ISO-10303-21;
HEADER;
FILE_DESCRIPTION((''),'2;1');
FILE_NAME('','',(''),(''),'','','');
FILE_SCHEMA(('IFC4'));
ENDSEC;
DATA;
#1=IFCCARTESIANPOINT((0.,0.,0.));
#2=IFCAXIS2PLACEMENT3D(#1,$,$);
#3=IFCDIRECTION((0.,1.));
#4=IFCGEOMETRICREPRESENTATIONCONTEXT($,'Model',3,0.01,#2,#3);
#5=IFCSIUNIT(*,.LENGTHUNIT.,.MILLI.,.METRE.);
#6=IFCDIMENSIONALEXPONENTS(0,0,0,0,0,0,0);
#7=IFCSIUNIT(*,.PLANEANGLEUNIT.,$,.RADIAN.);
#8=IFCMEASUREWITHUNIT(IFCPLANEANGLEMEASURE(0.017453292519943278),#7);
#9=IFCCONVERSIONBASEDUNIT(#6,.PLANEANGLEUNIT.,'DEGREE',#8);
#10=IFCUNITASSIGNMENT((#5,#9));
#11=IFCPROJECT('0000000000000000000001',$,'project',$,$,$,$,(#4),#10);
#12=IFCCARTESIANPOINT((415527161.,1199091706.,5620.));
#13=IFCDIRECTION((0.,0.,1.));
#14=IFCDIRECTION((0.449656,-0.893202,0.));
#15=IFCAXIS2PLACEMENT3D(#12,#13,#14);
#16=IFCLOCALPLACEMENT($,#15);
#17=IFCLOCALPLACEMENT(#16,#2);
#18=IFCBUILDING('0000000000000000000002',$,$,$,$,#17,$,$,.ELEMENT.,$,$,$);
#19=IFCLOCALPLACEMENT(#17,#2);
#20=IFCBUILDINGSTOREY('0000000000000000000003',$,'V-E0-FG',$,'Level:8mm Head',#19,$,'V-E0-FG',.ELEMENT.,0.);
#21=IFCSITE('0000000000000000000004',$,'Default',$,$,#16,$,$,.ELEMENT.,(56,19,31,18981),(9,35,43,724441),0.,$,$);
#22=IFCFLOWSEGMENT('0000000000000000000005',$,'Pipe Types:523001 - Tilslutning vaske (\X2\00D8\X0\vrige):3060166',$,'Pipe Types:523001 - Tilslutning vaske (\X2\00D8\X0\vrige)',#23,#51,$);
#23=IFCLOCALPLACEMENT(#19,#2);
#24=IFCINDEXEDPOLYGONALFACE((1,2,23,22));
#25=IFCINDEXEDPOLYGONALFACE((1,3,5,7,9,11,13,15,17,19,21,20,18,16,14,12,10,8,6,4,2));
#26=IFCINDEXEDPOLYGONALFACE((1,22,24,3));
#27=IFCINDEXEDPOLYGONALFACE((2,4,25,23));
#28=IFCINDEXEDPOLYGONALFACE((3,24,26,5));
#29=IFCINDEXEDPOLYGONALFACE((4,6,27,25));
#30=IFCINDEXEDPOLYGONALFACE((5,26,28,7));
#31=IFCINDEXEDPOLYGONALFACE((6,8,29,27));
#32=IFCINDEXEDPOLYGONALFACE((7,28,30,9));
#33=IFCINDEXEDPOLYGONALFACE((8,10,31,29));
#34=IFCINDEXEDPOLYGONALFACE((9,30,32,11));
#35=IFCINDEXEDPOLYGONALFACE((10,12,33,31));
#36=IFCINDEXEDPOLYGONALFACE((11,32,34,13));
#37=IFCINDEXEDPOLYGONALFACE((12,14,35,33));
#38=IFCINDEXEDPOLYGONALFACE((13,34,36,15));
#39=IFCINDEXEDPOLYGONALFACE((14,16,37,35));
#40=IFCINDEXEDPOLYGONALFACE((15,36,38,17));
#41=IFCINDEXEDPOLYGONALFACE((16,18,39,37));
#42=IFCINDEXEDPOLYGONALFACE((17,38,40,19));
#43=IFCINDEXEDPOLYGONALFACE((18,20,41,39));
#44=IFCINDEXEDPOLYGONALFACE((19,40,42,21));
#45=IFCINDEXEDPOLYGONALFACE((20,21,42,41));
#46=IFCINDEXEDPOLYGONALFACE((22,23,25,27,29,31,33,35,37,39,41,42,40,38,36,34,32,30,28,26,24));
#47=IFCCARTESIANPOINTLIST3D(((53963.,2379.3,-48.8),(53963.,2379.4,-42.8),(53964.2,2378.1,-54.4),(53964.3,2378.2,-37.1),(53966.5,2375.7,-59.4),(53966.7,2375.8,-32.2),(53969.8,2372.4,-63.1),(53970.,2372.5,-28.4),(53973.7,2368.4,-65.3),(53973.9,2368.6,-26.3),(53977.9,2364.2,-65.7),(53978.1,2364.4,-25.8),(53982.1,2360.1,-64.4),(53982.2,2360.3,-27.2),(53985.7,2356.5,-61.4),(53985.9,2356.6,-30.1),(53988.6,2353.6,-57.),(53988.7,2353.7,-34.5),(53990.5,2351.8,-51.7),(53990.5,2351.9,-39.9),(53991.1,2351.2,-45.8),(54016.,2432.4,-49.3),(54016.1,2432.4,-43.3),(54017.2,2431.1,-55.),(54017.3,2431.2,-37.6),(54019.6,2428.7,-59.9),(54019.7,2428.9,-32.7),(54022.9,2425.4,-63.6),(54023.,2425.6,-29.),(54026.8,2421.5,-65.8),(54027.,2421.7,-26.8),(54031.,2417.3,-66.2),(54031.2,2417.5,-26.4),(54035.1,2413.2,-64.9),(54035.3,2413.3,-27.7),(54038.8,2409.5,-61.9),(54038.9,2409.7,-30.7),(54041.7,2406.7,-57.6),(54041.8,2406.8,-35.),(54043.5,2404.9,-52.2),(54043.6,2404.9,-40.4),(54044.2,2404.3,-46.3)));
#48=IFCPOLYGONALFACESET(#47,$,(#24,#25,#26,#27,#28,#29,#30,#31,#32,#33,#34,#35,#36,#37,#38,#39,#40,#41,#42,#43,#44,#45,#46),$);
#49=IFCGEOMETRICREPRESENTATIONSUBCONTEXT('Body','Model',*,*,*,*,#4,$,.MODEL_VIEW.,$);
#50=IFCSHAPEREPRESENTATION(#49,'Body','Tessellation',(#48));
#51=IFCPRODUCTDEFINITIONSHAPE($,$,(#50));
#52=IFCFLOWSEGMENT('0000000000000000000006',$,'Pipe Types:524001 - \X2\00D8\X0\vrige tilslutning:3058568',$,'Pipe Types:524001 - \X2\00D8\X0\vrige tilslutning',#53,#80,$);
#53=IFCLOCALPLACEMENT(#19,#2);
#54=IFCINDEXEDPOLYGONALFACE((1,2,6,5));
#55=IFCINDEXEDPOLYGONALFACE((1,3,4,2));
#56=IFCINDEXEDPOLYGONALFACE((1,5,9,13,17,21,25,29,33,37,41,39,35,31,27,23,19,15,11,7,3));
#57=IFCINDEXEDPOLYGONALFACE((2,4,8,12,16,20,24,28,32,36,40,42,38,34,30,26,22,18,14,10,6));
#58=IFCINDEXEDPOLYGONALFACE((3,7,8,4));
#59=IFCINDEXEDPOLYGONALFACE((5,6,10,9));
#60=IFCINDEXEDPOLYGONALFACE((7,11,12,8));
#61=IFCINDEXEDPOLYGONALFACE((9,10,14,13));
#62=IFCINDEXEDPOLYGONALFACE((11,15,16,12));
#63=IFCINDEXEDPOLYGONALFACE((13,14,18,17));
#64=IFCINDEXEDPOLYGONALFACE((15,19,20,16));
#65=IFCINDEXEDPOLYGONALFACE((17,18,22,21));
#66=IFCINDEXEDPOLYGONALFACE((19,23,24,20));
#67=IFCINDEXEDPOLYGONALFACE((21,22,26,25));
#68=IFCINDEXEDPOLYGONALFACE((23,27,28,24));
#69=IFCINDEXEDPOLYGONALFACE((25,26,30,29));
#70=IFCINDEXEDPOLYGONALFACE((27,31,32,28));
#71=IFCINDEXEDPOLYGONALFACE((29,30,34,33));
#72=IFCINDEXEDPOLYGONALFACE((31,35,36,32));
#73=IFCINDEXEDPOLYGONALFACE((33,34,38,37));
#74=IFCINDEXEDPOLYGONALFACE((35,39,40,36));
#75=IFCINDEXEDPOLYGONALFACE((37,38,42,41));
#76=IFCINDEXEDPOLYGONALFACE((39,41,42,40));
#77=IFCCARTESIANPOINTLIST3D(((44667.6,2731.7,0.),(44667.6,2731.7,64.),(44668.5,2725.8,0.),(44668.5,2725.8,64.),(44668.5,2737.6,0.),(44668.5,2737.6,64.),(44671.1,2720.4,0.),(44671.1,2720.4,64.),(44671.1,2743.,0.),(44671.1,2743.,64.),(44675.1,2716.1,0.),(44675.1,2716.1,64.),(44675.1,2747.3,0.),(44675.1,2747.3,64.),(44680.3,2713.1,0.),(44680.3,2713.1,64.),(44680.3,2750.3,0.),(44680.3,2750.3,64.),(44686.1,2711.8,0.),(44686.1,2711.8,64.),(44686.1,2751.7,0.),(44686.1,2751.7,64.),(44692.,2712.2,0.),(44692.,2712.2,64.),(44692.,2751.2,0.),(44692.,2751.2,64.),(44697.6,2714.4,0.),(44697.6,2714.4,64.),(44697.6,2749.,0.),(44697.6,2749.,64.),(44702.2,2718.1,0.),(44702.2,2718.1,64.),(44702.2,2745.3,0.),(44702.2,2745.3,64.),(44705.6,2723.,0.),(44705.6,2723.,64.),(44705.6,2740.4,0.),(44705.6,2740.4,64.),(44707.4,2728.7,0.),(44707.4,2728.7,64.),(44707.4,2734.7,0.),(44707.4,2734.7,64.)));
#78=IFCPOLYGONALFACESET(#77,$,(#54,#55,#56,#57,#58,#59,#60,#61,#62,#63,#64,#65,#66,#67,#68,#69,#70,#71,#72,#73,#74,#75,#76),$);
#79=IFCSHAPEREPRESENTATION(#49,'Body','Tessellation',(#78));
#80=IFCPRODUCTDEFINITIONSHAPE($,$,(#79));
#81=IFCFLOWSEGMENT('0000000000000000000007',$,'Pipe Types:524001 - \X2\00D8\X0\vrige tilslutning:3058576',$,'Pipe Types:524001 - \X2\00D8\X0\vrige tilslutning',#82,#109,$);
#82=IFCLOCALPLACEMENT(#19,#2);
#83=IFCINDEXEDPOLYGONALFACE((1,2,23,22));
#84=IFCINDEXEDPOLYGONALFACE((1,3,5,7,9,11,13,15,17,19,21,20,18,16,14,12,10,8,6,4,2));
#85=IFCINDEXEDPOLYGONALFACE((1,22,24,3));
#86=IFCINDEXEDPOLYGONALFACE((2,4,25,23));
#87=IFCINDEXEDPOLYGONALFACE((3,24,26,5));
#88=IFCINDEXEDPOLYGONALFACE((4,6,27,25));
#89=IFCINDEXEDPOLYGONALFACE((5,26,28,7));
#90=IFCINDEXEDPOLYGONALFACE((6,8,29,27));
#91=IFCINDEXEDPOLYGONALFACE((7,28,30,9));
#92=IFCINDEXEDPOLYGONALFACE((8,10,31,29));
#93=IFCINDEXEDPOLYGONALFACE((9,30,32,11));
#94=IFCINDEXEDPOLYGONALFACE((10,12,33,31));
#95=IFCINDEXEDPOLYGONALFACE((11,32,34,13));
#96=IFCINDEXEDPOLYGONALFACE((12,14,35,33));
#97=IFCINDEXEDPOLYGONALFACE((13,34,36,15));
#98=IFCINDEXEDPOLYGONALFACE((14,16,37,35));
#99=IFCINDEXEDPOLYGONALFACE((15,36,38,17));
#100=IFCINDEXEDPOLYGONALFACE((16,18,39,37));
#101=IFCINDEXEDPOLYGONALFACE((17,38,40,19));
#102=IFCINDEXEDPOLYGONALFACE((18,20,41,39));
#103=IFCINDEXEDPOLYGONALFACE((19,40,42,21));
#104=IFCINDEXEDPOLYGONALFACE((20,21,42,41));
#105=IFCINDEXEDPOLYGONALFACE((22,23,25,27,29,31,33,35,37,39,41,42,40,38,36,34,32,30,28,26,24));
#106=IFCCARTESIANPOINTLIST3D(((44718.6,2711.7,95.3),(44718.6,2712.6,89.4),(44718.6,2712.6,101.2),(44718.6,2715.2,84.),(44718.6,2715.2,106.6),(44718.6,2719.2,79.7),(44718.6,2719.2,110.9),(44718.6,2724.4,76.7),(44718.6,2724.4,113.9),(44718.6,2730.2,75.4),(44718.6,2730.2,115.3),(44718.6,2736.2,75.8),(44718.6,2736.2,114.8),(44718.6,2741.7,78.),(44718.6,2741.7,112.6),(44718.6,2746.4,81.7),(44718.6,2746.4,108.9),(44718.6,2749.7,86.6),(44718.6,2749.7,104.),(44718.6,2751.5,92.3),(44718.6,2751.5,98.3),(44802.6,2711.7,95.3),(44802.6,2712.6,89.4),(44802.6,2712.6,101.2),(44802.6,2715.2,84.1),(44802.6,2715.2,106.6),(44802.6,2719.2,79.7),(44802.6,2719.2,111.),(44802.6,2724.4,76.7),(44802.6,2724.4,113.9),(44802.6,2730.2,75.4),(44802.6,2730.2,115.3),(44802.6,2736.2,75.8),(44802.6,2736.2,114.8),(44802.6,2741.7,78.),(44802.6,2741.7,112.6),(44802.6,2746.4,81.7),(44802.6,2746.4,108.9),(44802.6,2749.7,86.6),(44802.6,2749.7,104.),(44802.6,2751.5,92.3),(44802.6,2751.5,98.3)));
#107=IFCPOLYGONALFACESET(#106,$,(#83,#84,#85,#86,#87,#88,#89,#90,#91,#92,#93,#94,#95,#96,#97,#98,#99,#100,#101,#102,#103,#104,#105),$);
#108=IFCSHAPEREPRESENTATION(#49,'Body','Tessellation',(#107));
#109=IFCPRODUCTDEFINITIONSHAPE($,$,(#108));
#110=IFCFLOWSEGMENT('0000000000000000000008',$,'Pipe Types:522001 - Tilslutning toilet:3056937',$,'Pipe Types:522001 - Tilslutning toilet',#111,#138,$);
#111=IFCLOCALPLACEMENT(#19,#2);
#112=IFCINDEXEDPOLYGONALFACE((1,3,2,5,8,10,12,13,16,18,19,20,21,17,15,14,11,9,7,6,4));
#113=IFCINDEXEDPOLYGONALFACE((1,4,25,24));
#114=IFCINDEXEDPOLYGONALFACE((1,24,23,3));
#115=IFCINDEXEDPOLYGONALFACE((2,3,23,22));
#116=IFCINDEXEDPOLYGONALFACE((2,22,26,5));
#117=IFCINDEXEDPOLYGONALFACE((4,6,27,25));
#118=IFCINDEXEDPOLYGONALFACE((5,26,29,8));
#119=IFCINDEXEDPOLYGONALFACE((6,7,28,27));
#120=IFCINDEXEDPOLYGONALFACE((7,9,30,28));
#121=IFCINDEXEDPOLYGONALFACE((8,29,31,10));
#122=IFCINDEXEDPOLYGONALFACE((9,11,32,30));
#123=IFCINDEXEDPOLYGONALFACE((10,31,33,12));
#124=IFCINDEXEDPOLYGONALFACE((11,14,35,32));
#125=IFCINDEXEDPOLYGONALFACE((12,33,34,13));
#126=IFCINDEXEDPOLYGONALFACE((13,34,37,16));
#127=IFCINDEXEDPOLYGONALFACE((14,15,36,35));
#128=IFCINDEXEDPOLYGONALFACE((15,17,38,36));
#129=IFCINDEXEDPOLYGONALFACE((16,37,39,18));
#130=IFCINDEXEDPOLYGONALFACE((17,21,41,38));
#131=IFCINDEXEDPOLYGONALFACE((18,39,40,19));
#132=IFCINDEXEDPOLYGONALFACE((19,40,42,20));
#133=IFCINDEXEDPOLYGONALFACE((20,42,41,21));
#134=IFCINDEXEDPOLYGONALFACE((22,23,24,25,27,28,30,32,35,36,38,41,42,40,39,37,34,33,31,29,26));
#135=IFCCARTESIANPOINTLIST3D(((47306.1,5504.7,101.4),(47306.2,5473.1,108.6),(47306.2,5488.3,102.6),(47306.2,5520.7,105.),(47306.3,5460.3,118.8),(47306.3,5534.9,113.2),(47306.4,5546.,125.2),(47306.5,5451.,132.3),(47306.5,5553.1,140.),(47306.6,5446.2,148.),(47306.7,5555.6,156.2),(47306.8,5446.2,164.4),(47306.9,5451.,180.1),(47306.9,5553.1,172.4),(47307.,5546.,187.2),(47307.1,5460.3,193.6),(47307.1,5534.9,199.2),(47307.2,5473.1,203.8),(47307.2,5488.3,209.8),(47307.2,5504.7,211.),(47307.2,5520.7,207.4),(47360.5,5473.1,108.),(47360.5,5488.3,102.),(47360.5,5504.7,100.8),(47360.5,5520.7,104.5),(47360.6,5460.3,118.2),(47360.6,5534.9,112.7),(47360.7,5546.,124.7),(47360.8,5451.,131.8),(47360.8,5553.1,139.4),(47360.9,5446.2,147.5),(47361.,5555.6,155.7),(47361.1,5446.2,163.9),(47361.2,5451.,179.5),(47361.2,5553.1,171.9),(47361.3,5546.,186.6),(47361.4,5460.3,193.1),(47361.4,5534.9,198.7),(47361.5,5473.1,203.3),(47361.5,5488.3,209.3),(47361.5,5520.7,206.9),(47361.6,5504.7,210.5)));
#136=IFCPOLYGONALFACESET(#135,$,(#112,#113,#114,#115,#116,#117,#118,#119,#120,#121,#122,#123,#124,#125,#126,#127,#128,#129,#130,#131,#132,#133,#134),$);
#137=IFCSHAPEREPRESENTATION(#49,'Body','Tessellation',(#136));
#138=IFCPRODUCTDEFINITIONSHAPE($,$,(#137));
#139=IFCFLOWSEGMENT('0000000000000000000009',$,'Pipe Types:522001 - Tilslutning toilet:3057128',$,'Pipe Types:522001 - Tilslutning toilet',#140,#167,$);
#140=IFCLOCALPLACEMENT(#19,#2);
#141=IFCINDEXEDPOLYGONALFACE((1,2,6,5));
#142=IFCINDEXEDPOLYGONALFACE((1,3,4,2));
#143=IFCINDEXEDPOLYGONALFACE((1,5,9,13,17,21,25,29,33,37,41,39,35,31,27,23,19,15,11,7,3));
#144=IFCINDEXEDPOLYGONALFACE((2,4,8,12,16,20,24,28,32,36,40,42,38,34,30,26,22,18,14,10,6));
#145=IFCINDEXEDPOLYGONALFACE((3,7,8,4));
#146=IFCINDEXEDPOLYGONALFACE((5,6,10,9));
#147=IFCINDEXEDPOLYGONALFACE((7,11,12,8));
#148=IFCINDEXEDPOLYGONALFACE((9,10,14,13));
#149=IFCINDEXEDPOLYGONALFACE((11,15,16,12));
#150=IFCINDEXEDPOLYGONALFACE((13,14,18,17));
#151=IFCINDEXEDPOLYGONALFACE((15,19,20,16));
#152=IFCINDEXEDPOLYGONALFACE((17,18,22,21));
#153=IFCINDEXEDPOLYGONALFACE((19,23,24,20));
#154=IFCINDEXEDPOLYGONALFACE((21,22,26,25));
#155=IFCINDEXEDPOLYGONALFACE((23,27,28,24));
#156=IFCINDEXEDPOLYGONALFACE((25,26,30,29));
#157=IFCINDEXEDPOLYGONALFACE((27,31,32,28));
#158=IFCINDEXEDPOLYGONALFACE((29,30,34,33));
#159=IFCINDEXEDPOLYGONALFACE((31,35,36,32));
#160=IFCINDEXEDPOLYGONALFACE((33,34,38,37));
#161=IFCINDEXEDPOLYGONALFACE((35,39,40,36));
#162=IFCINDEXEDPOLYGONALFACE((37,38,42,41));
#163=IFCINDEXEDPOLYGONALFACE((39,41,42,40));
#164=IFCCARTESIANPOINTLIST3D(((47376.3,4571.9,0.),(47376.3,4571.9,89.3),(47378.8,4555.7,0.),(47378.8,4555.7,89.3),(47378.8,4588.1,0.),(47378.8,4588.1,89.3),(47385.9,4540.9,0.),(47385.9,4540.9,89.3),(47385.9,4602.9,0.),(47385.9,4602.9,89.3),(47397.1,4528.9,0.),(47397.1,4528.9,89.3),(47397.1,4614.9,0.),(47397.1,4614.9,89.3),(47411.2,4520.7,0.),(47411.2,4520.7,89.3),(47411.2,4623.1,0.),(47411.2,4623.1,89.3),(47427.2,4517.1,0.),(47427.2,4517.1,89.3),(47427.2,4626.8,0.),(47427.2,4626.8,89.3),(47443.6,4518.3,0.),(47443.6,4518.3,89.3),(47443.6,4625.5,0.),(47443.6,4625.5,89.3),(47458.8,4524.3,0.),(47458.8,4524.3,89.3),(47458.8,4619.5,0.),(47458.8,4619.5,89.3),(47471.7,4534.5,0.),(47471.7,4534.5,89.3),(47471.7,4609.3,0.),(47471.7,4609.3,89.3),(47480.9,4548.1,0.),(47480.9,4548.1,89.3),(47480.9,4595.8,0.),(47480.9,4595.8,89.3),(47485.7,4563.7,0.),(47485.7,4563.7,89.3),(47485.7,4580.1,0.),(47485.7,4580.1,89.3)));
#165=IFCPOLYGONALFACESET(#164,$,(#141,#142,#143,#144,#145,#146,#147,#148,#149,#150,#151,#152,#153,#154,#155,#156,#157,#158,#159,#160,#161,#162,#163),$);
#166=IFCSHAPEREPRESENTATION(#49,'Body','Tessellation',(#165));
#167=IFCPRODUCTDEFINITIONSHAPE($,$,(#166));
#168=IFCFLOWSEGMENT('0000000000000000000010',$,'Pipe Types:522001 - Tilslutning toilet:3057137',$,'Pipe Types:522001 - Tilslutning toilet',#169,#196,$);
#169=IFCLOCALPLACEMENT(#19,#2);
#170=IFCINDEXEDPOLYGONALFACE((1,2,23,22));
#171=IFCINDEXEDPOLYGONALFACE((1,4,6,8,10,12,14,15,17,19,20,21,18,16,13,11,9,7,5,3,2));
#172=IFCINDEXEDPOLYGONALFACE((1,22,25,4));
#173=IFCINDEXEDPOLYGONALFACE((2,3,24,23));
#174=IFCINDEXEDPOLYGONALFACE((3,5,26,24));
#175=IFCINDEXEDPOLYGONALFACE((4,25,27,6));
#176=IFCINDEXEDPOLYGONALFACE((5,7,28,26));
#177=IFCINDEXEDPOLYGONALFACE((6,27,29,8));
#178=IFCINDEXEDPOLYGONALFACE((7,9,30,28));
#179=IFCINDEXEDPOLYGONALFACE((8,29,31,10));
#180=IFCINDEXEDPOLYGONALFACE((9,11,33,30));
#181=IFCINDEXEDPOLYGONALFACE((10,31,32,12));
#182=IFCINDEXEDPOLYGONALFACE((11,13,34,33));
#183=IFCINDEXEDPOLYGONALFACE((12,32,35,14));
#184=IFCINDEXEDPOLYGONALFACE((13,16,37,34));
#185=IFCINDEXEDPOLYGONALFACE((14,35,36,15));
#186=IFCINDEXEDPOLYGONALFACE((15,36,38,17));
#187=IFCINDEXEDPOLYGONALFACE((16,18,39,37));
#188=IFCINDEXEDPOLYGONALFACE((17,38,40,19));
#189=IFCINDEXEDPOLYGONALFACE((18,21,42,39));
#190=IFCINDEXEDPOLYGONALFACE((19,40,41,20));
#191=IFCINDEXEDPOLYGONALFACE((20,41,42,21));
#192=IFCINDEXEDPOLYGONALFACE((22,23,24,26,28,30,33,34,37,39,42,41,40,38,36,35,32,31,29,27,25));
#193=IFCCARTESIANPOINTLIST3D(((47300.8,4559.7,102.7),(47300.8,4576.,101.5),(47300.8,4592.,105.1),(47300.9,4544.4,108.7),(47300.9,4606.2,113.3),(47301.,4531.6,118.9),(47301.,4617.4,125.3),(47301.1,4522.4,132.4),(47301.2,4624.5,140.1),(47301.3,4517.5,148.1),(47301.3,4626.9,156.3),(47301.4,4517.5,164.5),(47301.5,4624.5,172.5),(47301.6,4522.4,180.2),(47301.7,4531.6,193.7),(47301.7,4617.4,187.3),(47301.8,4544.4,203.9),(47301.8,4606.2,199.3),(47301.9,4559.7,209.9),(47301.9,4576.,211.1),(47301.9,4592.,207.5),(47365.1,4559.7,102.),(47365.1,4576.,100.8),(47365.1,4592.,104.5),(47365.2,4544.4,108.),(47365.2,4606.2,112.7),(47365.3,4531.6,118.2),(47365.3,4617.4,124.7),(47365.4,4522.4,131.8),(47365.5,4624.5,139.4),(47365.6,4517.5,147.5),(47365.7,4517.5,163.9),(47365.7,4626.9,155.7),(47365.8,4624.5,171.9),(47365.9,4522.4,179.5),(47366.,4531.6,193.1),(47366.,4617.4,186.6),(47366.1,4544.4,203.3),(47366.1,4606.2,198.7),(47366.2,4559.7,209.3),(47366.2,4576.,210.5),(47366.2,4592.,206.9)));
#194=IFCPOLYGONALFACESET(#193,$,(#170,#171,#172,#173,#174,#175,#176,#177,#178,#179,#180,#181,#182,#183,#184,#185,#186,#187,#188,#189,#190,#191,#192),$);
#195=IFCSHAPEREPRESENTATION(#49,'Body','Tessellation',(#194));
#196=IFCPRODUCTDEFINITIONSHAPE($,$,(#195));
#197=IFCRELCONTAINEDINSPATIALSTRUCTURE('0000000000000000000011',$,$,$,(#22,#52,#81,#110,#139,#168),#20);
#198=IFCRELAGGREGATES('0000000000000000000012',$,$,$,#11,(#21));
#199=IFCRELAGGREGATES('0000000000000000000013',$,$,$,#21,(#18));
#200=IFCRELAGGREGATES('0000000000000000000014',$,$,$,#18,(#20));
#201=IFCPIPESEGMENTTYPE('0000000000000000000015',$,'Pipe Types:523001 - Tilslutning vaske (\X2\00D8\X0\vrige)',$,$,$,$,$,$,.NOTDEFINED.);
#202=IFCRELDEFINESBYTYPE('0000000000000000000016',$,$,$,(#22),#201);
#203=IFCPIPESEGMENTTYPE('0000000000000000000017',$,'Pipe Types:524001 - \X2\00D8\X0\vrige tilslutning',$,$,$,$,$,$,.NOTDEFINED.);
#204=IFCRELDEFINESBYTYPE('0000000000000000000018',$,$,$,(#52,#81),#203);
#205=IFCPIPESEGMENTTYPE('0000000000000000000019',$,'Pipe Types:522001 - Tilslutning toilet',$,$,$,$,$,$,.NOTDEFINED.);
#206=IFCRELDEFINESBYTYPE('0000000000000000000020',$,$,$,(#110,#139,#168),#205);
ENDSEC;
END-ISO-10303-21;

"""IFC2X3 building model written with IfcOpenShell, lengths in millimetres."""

from ifc_helpers import new_model, entity, si_unit, converted_unit, direction, frame, frame_2d, origin, origin_2d_with_axis, place, context, subcontext, project, spatial, circle, extrude, type_object, element, save


model = new_model("IFC2X3")

# Units and contexts
model_context = context("Model", 3, precision=0.01, world=origin(), true_north=direction((0.0, 1.0)))
body_context = subcontext(model_context, "Body", "Model", "MODEL_VIEW")
ifc_project = project(units=[si_unit("LENGTHUNIT", "METRE", prefix="MILLI"), converted_unit("PLANEANGLEUNIT", "DEGREE", entity("IfcPlaneAngleMeasure", 0.017453292519943278), si_unit("PLANEANGLEUNIT", "RADIAN"), dimensions=[0, 0, 0, 0, 0, 0, 0])], contexts=[model_context])

# Site, building, storey
site_placement = place(None, frame((415527161.0, 1199091706.0, 5620.0), z_axis=(0.0, 0.0, 1.0), x_axis=(0.449656, -0.893202, 0.0)))
site = spatial("IfcSite", under=ifc_project, at=site_placement, Name="Default", CompositionType="ELEMENT", RefLatitude=(56, 19, 31, 18981), RefLongitude=(9, 35, 43, 724441), RefElevation=0.0)
building_placement = place(site_placement, origin())
building = spatial("IfcBuilding", under=site, at=building_placement, CompositionType="ELEMENT")
storey_placement = place(building_placement, origin())
storey = spatial("IfcBuildingStorey", under=building, at=storey_placement, Name="V-E0-FG", ObjectType="Level:8mm Head", LongName="V-E0-FG", CompositionType="ELEMENT", Elevation=0.0)

# Flow segments
pipe_segment_type_1 = type_object("IfcPipeSegmentType", Name="Pipe Types:523001 - Tilslutning vaske (Øvrige)", PredefinedType="NOTDEFINED")
flow_segment_1_placement = place(storey_placement, origin())
element("IfcFlowSegment", 1, at=flow_segment_1_placement, inside=storey, type_object=pipe_segment_type_1, Name="Pipe Types:523001 - Tilslutning vaske (Øvrige):3060166", ObjectType="Pipe Types:523001 - Tilslutning vaske (Øvrige)", context=body_context, shape_type="SweptSolid", body=[
    extrude(circle(Radius=20.0, at=frame_2d((0.0, 0.0), x_axis=(1.0, 0.0))), frame((53977.0, 2365.4, -45.8), z_axis=(0.707107, 0.707071, -0.007071), x_axis=(0.707089, -0.707124, 0.0)), (0.0, 0.0, 1.0), 75.0),
])
pipe_segment_type_2 = type_object("IfcPipeSegmentType", Name="Pipe Types:524001 - Øvrige tilslutning", PredefinedType="NOTDEFINED")
flow_segment_2_placement = place(storey_placement, origin())
element("IfcFlowSegment", 2, at=flow_segment_2_placement, inside=storey, type_object=pipe_segment_type_2, Name="Pipe Types:524001 - Øvrige tilslutning:3058568", ObjectType="Pipe Types:524001 - Øvrige tilslutning", context=body_context, shape_type="SweptSolid", body=[
    extrude(circle(Radius=20.0, at=origin_2d_with_axis()), frame((44687.6, 2731.7, 0.0), z_axis=(0.0, 0.0, 1.0), x_axis=(-1.0, 0.0, 0.0)), (0.0, 0.0, 1.0), 64.0),
])
flow_segment_3_placement = place(storey_placement, origin())
element("IfcFlowSegment", 3, at=flow_segment_3_placement, inside=storey, type_object=pipe_segment_type_2, Name="Pipe Types:524001 - Øvrige tilslutning:3058576", ObjectType="Pipe Types:524001 - Øvrige tilslutning", context=body_context, shape_type="SweptSolid", body=[
    extrude(circle(Radius=20.0, at=frame_2d((0.0, 0.0), x_axis=(1.0, 0.0))), frame((44718.6, 2731.7, 95.3), z_axis=(1.0, 0.0, 0.000133), x_axis=(0.0, -1.0, 0.0)), (0.0, 0.0, 1.0), 84.0),
])
pipe_segment_type_3 = type_object("IfcPipeSegmentType", Name="Pipe Types:522001 - Tilslutning toilet", PredefinedType="NOTDEFINED")
flow_segment_4_placement = place(storey_placement, origin())
element("IfcFlowSegment", 4, at=flow_segment_4_placement, inside=storey, type_object=pipe_segment_type_3, Name="Pipe Types:522001 - Tilslutning toilet:3056937", ObjectType="Pipe Types:522001 - Tilslutning toilet", context=body_context, shape_type="SweptSolid", body=[
    extrude(circle(Radius=55.0, at=frame_2d((0.0, 0.0), x_axis=(1.0, 0.0))), frame((47361.0, 5500.6, 155.7), z_axis=(-0.99995, 0.0, 0.01), x_axis=(0.0, 1.0, 0.0)), (0.0, 0.0, 1.0), 54.3),
])
flow_segment_5_placement = place(storey_placement, origin())
element("IfcFlowSegment", 5, at=flow_segment_5_placement, inside=storey, type_object=pipe_segment_type_3, Name="Pipe Types:522001 - Tilslutning toilet:3057128", ObjectType="Pipe Types:522001 - Tilslutning toilet", context=body_context, shape_type="SweptSolid", body=[
    extrude(circle(Radius=55.0, at=frame_2d((0.0, 0.0), x_axis=(1.0, 0.0))), frame((47431.3, 4571.9, 0.0), z_axis=(0.0, 0.0, 1.0), x_axis=(-1.0, 0.0, 0.0)), (0.0, 0.0, 1.0), 89.3),
])
flow_segment_6_placement = place(storey_placement, origin())
element("IfcFlowSegment", 6, at=flow_segment_6_placement, inside=storey, type_object=pipe_segment_type_3, Name="Pipe Types:522001 - Tilslutning toilet:3057137", ObjectType="Pipe Types:522001 - Tilslutning toilet", context=body_context, shape_type="SweptSolid", body=[
    extrude(circle(Radius=55.0, at=frame_2d((0.0, 0.0), x_axis=(1.0, 0.0))), frame((47365.7, 4571.9, 155.7), z_axis=(-0.99995, 0.0, 0.01), x_axis=(0.0, 1.0, 0.0)), (0.0, 0.0, 1.0), 64.3),
])

save(model, "model.ifc")
